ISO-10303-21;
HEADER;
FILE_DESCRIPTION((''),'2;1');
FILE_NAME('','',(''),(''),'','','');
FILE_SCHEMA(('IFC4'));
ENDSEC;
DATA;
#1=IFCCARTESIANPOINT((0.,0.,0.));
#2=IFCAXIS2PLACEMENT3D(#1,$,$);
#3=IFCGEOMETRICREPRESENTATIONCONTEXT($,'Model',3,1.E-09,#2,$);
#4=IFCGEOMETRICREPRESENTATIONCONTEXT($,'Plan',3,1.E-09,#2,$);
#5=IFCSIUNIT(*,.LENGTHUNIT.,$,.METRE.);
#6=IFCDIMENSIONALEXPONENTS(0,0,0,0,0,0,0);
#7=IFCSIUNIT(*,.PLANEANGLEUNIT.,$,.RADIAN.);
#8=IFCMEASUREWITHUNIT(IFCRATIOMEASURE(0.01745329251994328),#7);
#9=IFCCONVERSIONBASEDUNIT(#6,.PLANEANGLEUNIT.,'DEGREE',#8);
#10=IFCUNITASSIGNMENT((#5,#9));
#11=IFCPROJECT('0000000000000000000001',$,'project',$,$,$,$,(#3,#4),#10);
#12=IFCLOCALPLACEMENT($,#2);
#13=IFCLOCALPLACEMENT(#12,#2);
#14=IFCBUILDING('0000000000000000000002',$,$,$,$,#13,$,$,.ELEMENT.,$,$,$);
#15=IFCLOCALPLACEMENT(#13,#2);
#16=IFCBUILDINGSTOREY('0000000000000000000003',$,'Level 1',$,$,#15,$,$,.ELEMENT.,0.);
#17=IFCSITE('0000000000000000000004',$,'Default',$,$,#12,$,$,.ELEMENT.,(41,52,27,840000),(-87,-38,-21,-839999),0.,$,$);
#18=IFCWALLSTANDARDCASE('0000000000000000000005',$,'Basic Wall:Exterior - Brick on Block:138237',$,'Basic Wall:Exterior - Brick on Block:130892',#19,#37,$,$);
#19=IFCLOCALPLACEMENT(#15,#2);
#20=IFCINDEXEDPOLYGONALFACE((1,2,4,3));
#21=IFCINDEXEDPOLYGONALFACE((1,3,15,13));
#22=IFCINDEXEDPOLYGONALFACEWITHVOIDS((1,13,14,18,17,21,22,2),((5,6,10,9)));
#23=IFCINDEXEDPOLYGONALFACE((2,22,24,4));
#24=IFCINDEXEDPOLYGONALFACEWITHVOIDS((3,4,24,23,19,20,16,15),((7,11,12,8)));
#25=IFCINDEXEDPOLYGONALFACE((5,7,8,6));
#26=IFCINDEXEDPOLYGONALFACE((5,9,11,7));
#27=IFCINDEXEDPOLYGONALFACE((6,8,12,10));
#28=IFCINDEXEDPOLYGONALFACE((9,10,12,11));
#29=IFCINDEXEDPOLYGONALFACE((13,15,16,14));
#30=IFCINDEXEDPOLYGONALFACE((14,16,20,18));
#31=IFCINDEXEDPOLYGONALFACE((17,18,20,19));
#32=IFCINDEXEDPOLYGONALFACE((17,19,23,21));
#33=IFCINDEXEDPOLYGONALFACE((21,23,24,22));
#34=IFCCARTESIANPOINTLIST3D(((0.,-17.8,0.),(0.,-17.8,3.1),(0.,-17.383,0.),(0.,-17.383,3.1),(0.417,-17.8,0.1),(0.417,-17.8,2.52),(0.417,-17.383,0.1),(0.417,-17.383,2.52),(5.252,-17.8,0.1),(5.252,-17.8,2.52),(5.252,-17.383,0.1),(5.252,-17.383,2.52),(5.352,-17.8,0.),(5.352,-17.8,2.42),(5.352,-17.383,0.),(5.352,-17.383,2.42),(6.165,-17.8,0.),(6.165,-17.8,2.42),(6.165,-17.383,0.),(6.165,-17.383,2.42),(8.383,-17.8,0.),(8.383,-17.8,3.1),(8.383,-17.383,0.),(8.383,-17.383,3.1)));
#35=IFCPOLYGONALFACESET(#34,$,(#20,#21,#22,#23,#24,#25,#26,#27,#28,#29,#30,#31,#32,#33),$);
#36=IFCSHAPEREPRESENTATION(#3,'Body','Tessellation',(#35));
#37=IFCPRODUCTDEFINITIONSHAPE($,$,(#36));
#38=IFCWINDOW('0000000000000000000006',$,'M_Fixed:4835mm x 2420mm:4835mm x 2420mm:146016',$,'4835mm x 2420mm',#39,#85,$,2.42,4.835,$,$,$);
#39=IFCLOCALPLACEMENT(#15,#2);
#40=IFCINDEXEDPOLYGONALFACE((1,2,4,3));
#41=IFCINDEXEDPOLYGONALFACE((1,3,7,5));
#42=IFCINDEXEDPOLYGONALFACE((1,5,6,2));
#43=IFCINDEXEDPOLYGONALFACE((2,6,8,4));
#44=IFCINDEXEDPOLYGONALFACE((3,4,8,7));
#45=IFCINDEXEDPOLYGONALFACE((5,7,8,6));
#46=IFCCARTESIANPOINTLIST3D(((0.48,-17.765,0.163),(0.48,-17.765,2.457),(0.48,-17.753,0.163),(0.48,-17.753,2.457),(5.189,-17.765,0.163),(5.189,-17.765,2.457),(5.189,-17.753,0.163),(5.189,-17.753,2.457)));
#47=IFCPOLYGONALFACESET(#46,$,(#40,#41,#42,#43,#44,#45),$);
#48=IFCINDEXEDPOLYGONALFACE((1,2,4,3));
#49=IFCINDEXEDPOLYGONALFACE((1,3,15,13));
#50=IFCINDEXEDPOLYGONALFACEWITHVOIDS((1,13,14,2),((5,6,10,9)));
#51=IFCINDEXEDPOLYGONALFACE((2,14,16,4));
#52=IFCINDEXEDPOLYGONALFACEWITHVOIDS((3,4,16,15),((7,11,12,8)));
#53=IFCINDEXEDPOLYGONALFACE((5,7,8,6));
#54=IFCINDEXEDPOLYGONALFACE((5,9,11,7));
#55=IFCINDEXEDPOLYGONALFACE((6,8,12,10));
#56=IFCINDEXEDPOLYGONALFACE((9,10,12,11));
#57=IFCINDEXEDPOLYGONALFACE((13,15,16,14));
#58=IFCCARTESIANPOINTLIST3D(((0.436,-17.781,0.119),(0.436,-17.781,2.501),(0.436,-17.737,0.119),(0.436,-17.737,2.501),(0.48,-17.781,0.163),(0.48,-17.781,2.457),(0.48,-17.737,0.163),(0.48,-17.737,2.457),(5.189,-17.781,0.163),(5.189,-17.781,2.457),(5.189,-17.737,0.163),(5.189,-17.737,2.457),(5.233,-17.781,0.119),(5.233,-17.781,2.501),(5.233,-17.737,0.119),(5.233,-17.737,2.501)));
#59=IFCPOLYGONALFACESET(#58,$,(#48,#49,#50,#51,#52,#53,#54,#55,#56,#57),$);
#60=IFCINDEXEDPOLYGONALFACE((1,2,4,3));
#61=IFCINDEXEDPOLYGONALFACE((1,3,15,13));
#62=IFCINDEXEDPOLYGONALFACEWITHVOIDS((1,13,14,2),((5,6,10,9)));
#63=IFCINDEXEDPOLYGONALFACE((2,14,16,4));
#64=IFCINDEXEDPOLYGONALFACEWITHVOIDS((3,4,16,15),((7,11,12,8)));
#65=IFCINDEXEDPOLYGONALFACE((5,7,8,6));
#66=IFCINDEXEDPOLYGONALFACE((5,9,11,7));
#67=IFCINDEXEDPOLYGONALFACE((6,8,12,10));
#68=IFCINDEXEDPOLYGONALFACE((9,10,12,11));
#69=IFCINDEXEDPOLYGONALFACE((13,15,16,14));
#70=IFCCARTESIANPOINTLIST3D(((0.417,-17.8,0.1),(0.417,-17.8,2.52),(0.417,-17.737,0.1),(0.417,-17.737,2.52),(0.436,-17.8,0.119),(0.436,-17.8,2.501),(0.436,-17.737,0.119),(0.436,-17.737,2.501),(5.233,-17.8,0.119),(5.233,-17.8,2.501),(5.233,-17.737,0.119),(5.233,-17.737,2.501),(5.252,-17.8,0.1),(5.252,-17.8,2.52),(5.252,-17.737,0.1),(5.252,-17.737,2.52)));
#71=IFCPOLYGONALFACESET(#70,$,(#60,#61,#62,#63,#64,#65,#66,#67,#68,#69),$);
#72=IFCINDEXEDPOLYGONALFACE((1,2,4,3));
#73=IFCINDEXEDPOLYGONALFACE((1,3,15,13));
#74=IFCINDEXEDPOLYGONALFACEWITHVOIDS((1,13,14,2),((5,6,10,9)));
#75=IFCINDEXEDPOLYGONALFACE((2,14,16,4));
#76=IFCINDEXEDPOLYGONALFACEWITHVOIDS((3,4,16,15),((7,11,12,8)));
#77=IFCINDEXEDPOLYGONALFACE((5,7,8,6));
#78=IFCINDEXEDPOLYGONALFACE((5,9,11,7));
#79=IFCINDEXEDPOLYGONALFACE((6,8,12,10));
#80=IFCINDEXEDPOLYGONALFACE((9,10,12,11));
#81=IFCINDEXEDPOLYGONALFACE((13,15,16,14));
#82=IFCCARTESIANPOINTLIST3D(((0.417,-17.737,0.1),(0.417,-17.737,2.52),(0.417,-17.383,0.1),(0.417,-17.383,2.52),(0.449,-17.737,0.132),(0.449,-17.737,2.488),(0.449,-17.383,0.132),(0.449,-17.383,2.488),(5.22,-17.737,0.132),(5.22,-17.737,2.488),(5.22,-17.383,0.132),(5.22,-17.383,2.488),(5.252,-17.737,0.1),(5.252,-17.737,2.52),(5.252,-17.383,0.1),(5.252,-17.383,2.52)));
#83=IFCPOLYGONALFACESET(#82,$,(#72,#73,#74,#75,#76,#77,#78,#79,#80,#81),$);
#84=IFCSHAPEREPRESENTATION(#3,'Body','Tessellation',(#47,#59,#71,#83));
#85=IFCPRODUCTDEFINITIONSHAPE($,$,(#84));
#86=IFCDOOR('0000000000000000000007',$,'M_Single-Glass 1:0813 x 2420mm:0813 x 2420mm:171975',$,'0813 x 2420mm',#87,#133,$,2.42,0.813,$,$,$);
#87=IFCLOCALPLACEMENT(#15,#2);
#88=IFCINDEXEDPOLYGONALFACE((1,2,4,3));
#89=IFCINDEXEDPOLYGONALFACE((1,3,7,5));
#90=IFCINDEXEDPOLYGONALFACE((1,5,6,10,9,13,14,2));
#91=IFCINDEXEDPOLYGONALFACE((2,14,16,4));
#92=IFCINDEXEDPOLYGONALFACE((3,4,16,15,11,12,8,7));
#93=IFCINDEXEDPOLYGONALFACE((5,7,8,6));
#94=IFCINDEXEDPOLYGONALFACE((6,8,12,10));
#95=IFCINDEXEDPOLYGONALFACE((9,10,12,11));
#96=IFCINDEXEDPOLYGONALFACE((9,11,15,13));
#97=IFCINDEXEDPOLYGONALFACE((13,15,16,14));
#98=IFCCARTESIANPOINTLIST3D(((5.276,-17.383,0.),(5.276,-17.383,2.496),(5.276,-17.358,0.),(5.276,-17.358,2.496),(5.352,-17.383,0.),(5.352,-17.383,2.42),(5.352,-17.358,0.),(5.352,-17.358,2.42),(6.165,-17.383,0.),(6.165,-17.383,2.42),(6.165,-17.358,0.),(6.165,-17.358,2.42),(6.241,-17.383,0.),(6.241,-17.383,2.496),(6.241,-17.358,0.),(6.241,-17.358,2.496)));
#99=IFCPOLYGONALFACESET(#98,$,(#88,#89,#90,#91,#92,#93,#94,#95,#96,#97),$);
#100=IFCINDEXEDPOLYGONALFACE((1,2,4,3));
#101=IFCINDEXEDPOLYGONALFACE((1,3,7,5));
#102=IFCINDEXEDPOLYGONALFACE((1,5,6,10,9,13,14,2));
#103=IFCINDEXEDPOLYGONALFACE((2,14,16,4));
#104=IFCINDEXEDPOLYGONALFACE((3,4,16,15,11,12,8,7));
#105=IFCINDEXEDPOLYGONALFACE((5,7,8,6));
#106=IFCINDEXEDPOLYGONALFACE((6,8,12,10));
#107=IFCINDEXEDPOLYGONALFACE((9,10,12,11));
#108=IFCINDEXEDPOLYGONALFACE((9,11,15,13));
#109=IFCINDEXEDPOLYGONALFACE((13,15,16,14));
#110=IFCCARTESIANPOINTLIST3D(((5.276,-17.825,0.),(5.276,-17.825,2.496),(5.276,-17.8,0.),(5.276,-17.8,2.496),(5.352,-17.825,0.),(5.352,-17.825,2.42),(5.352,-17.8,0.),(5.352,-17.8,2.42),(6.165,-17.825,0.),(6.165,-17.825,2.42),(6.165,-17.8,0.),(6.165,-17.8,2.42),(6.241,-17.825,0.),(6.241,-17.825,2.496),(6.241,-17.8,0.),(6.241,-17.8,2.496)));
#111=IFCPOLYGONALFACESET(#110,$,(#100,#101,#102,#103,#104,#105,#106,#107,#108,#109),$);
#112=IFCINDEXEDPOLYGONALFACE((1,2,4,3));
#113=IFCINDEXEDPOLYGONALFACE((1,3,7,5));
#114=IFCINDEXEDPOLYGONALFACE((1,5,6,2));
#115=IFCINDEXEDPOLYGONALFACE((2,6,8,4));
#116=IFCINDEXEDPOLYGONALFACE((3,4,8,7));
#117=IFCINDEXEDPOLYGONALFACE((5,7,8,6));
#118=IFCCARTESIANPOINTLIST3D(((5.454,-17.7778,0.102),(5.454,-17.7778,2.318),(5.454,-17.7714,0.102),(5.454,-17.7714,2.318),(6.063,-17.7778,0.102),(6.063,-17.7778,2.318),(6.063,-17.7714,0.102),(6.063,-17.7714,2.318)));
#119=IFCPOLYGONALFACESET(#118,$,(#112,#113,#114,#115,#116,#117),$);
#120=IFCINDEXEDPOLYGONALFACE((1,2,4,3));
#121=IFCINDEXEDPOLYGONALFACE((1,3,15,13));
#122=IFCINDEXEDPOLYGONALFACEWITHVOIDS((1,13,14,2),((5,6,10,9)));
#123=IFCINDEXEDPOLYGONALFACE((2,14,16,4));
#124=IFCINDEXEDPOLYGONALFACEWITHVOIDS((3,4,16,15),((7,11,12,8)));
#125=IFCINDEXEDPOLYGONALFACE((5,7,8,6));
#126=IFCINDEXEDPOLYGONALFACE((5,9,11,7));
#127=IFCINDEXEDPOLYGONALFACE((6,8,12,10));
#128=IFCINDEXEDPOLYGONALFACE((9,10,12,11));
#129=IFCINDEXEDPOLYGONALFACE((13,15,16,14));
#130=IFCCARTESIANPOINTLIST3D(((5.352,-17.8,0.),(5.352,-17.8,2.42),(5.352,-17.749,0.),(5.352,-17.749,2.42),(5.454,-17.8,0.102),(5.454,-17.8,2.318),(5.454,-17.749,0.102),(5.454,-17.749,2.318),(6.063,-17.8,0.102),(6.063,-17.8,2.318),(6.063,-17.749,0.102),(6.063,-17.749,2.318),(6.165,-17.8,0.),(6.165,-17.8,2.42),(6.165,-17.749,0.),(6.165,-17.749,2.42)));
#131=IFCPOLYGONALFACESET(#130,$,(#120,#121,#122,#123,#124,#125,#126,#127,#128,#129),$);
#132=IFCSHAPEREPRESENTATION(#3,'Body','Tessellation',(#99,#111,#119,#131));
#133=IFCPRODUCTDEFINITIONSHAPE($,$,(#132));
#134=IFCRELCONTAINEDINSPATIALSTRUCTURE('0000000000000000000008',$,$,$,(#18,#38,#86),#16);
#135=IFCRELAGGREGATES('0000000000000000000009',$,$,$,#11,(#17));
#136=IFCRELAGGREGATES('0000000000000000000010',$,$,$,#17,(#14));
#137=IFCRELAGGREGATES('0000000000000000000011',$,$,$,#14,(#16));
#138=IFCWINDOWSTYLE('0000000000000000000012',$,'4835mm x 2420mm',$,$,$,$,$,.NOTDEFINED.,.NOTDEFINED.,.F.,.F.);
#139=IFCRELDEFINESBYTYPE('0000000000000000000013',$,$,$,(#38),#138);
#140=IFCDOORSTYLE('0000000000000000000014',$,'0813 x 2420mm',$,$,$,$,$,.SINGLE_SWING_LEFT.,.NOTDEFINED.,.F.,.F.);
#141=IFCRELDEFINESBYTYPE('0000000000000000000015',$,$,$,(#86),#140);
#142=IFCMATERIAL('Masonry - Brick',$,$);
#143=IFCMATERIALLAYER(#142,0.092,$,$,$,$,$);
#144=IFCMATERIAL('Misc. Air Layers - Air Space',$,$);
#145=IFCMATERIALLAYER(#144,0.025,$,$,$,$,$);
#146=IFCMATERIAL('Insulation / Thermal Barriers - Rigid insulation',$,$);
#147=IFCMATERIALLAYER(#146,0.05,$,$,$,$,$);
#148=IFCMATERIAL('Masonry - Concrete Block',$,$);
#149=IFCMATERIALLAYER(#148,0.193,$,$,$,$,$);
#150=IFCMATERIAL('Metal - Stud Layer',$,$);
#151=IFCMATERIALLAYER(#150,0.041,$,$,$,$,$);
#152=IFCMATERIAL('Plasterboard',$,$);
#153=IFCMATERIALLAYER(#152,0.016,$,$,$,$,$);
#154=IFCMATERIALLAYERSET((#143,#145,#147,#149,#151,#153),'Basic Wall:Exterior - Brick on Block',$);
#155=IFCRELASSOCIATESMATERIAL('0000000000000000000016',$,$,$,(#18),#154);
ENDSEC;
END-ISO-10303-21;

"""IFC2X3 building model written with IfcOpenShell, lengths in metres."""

from ifc_helpers import new_model, entity, si_unit, converted_unit, frame, frame_2d, origin, origin_2d_with_axis, place, context, project, spatial, polyline, rectangle, outline, extrude, source, transform, mapped, material, layer, layer_set, layer_usage, type_object, type_shapes, element, fill, save


model = new_model("IFC2X3")

# Units and contexts
model_context = context("Model", 3, precision=1e-09, world=origin())
plan_context = context("Plan", 3, precision=1e-09, world=origin())
ifc_project = project(units=[si_unit("LENGTHUNIT", "METRE"), converted_unit("PLANEANGLEUNIT", "DEGREE", entity("IfcRatioMeasure", 0.01745329251994328), si_unit("PLANEANGLEUNIT", "RADIAN"), dimensions=[0, 0, 0, 0, 0, 0, 0])], contexts=[model_context, plan_context])

# Site, building, storey
site_placement = place(None, origin())
site = spatial("IfcSite", under=ifc_project, at=site_placement, Name="Default", CompositionType="ELEMENT", RefLatitude=(41, 52, 27, 840000), RefLongitude=(-87, -38, -21, -839999), RefElevation=0.0)
building_placement = place(site_placement, origin())
building = spatial("IfcBuilding", under=site, at=building_placement, CompositionType="ELEMENT")
storey_placement = place(building_placement, origin())
storey = spatial("IfcBuildingStorey", under=building, at=storey_placement, Name="Level 1", CompositionType="ELEMENT", Elevation=0.0)

# Wall, openings, window, door
ifc_material_1 = material(Name="Masonry - Brick")
ifc_layer_1 = layer(ifc_material_1, 0.092)
ifc_material_2 = material(Name="Misc. Air Layers - Air Space")
ifc_layer_2 = layer(ifc_material_2, 0.025)
ifc_material_3 = material(Name="Insulation / Thermal Barriers - Rigid insulation")
ifc_layer_3 = layer(ifc_material_3, 0.05)
ifc_material_4 = material(Name="Masonry - Concrete Block")
ifc_layer_4 = layer(ifc_material_4, 0.193)
ifc_material_5 = material(Name="Metal - Stud Layer")
ifc_layer_5 = layer(ifc_material_5, 0.041)
ifc_material_6 = material(Name="Plasterboard")
ifc_layer_6 = layer(ifc_material_6, 0.016)
ifc_layer_set_1 = layer_set([ifc_layer_1, ifc_layer_2, ifc_layer_3, ifc_layer_4, ifc_layer_5, ifc_layer_6], Name="Basic Wall:Exterior - Brick on Block")
ifc_layer_usage_1 = layer_usage(ifc_layer_set_1, "AXIS2", "NEGATIVE", 0.2085)
wall_1_placement = place(storey_placement, frame((8.383, -17.5915, 0.0), z_axis=(0.0, 0.0, 1.0), x_axis=(-1.0, 0.0, 0.0)))
wall_1 = element("IfcWallStandardCase", 1, at=wall_1_placement, inside=storey, material=ifc_layer_usage_1, Name="Basic Wall:Exterior - Brick on Block:138237", ObjectType="Basic Wall:Exterior - Brick on Block:130892", context=model_context, shape_type="SweptSolid", body=[
    extrude(rectangle(XDim=8.383, YDim=0.417, at=frame_2d((4.1915, 0.0), x_axis=(-1.0, 0.0))), origin(), (0.0, 0.0, 1.0), 3.1),
])
opening_1_placement = place(wall_1_placement, frame((3.131, -0.2085, 0.1)))
opening_1 = element("IfcOpeningElement", 2, at=opening_1_placement, cuts=wall_1, ObjectType="Opening", context=model_context, shape_type="SweptSolid", body=[
    extrude(rectangle(XDim=2.42, YDim=4.835, at=frame_2d((1.21, 2.4175), x_axis=(1.0, 0.0))), frame((0.0, 0.0, 0.0), z_axis=(0.0, 1.0, 0.0), x_axis=(0.0, 0.0, 1.0)), (0.0, 0.0, 1.0), 0.417),
])
opening_2_placement = place(wall_1_placement, frame((2.218, -0.2085, 0.0)))
opening_2 = element("IfcOpeningElement", 3, at=opening_2_placement, cuts=wall_1, ObjectType="Opening", context=model_context, shape_type="SweptSolid", body=[
    extrude(rectangle(XDim=0.813, YDim=2.42, at=frame_2d((1.21, 0.4065), x_axis=(0.0, -1.0))), frame((0.0, 0.0, 0.0), z_axis=(0.0, 1.0, 0.0), x_axis=(0.0, 0.0, 1.0)), (0.0, 0.0, 1.0), 0.417),
])
window_style_1 = type_object("IfcWindowStyle", Name="4835mm x 2420mm", ConstructionType="NOTDEFINED", OperationType="NOTDEFINED", ParameterTakesPrecedence=False, Sizeable=False)
shared_shape_1 = source(origin(), model_context, "Body", "SweptSolid", [
    extrude(rectangle(XDim=0.012, YDim=4.709, at=origin_2d_with_axis()), frame((2.4175, 0.376, 0.063), z_axis=(0.0, 0.0, 1.0), x_axis=(0.0, -1.0, 0.0)), (0.0, 0.0, 1.0), 2.294),
    extrude(outline(polyline([(-2.3985, -1.191), (2.3985, -1.191), (2.3985, 1.191), (-2.3985, 1.191), (-2.3985, -1.191)]), holes=[polyline([(-2.3545, -1.147), (-2.3545, 1.147), (2.3545, 1.147), (2.3545, -1.147), (-2.3545, -1.147)])]), frame((2.4175, 0.354, 1.21), z_axis=(0.0, 1.0, 0.0), x_axis=(1.0, 0.0, 0.0)), (0.0, 0.0, 1.0), 0.044),
    extrude(outline(polyline([(-2.4175, -1.21), (2.4175, -1.21), (2.4175, 1.21), (-2.4175, 1.21), (-2.4175, -1.21)]), holes=[polyline([(-2.3985, -1.191), (-2.3985, 1.191), (2.3985, 1.191), (2.3985, -1.191), (-2.3985, -1.191)])]), frame((2.4175, 0.354, 1.21), z_axis=(0.0, 1.0, 0.0), x_axis=(1.0, 0.0, 0.0)), (0.0, 0.0, 1.0), 0.063),
    extrude(outline(polyline([(-2.4175, -1.21), (2.4175, -1.21), (2.4175, 1.21), (-2.4175, 1.21), (-2.4175, -1.21)]), holes=[polyline([(-2.3855, -1.178), (-2.3855, 1.178), (2.3855, 1.178), (2.3855, -1.178), (-2.3855, -1.178)])]), frame((2.4175, 0.0, 1.21), z_axis=(0.0, 1.0, 0.0), x_axis=(1.0, 0.0, 0.0)), (0.0, 0.0, 1.0), 0.354),
])
type_shapes(window_style_1, [shared_shape_1])
window_1_placement = place(opening_1_placement, origin())
window_1 = element("IfcWindow", 4, at=window_1_placement, inside=storey, type_object=window_style_1, Name="M_Fixed:4835mm x 2420mm:4835mm x 2420mm:146016", ObjectType="4835mm x 2420mm", OverallHeight=2.42, OverallWidth=4.835, context=model_context, shape_type="MappedRepresentation", body=[
    mapped(shared_shape_1, transform((0.0, 0.0, 0.0), scale=1.0)),
])
fill(opening_1, window_1)
door_style_1 = type_object("IfcDoorStyle", Name="0813 x 2420mm", ConstructionType="NOTDEFINED", OperationType="SINGLE_SWING_LEFT", ParameterTakesPrecedence=False, Sizeable=False)
shared_shape_2 = source(origin(), model_context, "Body", "SweptSolid", [
    extrude(outline(polyline([(-0.4065, -1.191), (-0.4065, 1.229), (-0.4825, 1.229), (-0.4825, -1.267), (0.4825, -1.267), (0.4825, 1.229), (0.4065, 1.229), (0.4065, -1.191), (-0.4065, -1.191)])), frame((0.4065, 0.0, 1.229), z_axis=(0.0, 1.0, 0.0), x_axis=(1.0, 0.0, 0.0)), (0.0, 0.0, -1.0), 0.025),
    extrude(outline(polyline([(-0.4065, -1.191), (-0.4065, 1.229), (-0.4825, 1.229), (-0.4825, -1.267), (0.4825, -1.267), (0.4825, 1.229), (0.4065, 1.229), (0.4065, -1.191), (-0.4065, -1.191)])), frame((0.4065, 0.442, 1.229), z_axis=(0.0, 1.0, 0.0), x_axis=(1.0, 0.0, 0.0)), (0.0, 0.0, -1.0), 0.025),
    extrude(rectangle(XDim=0.609, YDim=0.0064, at=origin_2d_with_axis()), frame((0.4065, 0.3916, 0.102)), (0.0, 0.0, 1.0), 2.216),
    extrude(outline(polyline([(-1.21, -0.4065), (1.21, -0.4065), (1.21, 0.4065), (-1.21, 0.4065), (-1.21, -0.4065)]), holes=[polyline([(-1.108, 0.3045), (1.108, 0.3045), (1.108, -0.3045), (-1.108, -0.3045), (-1.108, 0.3045)])]), frame((0.4065, 0.417, 1.21), z_axis=(0.0, -1.0, 0.0), x_axis=(0.0, 0.0, -1.0)), (0.0, 0.0, 1.0), 0.051),
])
type_shapes(door_style_1, [shared_shape_2])
door_1_placement = place(opening_2_placement, origin())
door_1 = element("IfcDoor", 5, at=door_1_placement, inside=storey, type_object=door_style_1, Name="M_Single-Glass 1:0813 x 2420mm:0813 x 2420mm:171975", ObjectType="0813 x 2420mm", OverallHeight=2.42, OverallWidth=0.813, context=model_context, shape_type="MappedRepresentation", body=[
    mapped(shared_shape_2, transform((0.0, 0.0, 0.0), scale=1.0)),
])
fill(opening_2, door_1)

save(model, "model.ifc")
